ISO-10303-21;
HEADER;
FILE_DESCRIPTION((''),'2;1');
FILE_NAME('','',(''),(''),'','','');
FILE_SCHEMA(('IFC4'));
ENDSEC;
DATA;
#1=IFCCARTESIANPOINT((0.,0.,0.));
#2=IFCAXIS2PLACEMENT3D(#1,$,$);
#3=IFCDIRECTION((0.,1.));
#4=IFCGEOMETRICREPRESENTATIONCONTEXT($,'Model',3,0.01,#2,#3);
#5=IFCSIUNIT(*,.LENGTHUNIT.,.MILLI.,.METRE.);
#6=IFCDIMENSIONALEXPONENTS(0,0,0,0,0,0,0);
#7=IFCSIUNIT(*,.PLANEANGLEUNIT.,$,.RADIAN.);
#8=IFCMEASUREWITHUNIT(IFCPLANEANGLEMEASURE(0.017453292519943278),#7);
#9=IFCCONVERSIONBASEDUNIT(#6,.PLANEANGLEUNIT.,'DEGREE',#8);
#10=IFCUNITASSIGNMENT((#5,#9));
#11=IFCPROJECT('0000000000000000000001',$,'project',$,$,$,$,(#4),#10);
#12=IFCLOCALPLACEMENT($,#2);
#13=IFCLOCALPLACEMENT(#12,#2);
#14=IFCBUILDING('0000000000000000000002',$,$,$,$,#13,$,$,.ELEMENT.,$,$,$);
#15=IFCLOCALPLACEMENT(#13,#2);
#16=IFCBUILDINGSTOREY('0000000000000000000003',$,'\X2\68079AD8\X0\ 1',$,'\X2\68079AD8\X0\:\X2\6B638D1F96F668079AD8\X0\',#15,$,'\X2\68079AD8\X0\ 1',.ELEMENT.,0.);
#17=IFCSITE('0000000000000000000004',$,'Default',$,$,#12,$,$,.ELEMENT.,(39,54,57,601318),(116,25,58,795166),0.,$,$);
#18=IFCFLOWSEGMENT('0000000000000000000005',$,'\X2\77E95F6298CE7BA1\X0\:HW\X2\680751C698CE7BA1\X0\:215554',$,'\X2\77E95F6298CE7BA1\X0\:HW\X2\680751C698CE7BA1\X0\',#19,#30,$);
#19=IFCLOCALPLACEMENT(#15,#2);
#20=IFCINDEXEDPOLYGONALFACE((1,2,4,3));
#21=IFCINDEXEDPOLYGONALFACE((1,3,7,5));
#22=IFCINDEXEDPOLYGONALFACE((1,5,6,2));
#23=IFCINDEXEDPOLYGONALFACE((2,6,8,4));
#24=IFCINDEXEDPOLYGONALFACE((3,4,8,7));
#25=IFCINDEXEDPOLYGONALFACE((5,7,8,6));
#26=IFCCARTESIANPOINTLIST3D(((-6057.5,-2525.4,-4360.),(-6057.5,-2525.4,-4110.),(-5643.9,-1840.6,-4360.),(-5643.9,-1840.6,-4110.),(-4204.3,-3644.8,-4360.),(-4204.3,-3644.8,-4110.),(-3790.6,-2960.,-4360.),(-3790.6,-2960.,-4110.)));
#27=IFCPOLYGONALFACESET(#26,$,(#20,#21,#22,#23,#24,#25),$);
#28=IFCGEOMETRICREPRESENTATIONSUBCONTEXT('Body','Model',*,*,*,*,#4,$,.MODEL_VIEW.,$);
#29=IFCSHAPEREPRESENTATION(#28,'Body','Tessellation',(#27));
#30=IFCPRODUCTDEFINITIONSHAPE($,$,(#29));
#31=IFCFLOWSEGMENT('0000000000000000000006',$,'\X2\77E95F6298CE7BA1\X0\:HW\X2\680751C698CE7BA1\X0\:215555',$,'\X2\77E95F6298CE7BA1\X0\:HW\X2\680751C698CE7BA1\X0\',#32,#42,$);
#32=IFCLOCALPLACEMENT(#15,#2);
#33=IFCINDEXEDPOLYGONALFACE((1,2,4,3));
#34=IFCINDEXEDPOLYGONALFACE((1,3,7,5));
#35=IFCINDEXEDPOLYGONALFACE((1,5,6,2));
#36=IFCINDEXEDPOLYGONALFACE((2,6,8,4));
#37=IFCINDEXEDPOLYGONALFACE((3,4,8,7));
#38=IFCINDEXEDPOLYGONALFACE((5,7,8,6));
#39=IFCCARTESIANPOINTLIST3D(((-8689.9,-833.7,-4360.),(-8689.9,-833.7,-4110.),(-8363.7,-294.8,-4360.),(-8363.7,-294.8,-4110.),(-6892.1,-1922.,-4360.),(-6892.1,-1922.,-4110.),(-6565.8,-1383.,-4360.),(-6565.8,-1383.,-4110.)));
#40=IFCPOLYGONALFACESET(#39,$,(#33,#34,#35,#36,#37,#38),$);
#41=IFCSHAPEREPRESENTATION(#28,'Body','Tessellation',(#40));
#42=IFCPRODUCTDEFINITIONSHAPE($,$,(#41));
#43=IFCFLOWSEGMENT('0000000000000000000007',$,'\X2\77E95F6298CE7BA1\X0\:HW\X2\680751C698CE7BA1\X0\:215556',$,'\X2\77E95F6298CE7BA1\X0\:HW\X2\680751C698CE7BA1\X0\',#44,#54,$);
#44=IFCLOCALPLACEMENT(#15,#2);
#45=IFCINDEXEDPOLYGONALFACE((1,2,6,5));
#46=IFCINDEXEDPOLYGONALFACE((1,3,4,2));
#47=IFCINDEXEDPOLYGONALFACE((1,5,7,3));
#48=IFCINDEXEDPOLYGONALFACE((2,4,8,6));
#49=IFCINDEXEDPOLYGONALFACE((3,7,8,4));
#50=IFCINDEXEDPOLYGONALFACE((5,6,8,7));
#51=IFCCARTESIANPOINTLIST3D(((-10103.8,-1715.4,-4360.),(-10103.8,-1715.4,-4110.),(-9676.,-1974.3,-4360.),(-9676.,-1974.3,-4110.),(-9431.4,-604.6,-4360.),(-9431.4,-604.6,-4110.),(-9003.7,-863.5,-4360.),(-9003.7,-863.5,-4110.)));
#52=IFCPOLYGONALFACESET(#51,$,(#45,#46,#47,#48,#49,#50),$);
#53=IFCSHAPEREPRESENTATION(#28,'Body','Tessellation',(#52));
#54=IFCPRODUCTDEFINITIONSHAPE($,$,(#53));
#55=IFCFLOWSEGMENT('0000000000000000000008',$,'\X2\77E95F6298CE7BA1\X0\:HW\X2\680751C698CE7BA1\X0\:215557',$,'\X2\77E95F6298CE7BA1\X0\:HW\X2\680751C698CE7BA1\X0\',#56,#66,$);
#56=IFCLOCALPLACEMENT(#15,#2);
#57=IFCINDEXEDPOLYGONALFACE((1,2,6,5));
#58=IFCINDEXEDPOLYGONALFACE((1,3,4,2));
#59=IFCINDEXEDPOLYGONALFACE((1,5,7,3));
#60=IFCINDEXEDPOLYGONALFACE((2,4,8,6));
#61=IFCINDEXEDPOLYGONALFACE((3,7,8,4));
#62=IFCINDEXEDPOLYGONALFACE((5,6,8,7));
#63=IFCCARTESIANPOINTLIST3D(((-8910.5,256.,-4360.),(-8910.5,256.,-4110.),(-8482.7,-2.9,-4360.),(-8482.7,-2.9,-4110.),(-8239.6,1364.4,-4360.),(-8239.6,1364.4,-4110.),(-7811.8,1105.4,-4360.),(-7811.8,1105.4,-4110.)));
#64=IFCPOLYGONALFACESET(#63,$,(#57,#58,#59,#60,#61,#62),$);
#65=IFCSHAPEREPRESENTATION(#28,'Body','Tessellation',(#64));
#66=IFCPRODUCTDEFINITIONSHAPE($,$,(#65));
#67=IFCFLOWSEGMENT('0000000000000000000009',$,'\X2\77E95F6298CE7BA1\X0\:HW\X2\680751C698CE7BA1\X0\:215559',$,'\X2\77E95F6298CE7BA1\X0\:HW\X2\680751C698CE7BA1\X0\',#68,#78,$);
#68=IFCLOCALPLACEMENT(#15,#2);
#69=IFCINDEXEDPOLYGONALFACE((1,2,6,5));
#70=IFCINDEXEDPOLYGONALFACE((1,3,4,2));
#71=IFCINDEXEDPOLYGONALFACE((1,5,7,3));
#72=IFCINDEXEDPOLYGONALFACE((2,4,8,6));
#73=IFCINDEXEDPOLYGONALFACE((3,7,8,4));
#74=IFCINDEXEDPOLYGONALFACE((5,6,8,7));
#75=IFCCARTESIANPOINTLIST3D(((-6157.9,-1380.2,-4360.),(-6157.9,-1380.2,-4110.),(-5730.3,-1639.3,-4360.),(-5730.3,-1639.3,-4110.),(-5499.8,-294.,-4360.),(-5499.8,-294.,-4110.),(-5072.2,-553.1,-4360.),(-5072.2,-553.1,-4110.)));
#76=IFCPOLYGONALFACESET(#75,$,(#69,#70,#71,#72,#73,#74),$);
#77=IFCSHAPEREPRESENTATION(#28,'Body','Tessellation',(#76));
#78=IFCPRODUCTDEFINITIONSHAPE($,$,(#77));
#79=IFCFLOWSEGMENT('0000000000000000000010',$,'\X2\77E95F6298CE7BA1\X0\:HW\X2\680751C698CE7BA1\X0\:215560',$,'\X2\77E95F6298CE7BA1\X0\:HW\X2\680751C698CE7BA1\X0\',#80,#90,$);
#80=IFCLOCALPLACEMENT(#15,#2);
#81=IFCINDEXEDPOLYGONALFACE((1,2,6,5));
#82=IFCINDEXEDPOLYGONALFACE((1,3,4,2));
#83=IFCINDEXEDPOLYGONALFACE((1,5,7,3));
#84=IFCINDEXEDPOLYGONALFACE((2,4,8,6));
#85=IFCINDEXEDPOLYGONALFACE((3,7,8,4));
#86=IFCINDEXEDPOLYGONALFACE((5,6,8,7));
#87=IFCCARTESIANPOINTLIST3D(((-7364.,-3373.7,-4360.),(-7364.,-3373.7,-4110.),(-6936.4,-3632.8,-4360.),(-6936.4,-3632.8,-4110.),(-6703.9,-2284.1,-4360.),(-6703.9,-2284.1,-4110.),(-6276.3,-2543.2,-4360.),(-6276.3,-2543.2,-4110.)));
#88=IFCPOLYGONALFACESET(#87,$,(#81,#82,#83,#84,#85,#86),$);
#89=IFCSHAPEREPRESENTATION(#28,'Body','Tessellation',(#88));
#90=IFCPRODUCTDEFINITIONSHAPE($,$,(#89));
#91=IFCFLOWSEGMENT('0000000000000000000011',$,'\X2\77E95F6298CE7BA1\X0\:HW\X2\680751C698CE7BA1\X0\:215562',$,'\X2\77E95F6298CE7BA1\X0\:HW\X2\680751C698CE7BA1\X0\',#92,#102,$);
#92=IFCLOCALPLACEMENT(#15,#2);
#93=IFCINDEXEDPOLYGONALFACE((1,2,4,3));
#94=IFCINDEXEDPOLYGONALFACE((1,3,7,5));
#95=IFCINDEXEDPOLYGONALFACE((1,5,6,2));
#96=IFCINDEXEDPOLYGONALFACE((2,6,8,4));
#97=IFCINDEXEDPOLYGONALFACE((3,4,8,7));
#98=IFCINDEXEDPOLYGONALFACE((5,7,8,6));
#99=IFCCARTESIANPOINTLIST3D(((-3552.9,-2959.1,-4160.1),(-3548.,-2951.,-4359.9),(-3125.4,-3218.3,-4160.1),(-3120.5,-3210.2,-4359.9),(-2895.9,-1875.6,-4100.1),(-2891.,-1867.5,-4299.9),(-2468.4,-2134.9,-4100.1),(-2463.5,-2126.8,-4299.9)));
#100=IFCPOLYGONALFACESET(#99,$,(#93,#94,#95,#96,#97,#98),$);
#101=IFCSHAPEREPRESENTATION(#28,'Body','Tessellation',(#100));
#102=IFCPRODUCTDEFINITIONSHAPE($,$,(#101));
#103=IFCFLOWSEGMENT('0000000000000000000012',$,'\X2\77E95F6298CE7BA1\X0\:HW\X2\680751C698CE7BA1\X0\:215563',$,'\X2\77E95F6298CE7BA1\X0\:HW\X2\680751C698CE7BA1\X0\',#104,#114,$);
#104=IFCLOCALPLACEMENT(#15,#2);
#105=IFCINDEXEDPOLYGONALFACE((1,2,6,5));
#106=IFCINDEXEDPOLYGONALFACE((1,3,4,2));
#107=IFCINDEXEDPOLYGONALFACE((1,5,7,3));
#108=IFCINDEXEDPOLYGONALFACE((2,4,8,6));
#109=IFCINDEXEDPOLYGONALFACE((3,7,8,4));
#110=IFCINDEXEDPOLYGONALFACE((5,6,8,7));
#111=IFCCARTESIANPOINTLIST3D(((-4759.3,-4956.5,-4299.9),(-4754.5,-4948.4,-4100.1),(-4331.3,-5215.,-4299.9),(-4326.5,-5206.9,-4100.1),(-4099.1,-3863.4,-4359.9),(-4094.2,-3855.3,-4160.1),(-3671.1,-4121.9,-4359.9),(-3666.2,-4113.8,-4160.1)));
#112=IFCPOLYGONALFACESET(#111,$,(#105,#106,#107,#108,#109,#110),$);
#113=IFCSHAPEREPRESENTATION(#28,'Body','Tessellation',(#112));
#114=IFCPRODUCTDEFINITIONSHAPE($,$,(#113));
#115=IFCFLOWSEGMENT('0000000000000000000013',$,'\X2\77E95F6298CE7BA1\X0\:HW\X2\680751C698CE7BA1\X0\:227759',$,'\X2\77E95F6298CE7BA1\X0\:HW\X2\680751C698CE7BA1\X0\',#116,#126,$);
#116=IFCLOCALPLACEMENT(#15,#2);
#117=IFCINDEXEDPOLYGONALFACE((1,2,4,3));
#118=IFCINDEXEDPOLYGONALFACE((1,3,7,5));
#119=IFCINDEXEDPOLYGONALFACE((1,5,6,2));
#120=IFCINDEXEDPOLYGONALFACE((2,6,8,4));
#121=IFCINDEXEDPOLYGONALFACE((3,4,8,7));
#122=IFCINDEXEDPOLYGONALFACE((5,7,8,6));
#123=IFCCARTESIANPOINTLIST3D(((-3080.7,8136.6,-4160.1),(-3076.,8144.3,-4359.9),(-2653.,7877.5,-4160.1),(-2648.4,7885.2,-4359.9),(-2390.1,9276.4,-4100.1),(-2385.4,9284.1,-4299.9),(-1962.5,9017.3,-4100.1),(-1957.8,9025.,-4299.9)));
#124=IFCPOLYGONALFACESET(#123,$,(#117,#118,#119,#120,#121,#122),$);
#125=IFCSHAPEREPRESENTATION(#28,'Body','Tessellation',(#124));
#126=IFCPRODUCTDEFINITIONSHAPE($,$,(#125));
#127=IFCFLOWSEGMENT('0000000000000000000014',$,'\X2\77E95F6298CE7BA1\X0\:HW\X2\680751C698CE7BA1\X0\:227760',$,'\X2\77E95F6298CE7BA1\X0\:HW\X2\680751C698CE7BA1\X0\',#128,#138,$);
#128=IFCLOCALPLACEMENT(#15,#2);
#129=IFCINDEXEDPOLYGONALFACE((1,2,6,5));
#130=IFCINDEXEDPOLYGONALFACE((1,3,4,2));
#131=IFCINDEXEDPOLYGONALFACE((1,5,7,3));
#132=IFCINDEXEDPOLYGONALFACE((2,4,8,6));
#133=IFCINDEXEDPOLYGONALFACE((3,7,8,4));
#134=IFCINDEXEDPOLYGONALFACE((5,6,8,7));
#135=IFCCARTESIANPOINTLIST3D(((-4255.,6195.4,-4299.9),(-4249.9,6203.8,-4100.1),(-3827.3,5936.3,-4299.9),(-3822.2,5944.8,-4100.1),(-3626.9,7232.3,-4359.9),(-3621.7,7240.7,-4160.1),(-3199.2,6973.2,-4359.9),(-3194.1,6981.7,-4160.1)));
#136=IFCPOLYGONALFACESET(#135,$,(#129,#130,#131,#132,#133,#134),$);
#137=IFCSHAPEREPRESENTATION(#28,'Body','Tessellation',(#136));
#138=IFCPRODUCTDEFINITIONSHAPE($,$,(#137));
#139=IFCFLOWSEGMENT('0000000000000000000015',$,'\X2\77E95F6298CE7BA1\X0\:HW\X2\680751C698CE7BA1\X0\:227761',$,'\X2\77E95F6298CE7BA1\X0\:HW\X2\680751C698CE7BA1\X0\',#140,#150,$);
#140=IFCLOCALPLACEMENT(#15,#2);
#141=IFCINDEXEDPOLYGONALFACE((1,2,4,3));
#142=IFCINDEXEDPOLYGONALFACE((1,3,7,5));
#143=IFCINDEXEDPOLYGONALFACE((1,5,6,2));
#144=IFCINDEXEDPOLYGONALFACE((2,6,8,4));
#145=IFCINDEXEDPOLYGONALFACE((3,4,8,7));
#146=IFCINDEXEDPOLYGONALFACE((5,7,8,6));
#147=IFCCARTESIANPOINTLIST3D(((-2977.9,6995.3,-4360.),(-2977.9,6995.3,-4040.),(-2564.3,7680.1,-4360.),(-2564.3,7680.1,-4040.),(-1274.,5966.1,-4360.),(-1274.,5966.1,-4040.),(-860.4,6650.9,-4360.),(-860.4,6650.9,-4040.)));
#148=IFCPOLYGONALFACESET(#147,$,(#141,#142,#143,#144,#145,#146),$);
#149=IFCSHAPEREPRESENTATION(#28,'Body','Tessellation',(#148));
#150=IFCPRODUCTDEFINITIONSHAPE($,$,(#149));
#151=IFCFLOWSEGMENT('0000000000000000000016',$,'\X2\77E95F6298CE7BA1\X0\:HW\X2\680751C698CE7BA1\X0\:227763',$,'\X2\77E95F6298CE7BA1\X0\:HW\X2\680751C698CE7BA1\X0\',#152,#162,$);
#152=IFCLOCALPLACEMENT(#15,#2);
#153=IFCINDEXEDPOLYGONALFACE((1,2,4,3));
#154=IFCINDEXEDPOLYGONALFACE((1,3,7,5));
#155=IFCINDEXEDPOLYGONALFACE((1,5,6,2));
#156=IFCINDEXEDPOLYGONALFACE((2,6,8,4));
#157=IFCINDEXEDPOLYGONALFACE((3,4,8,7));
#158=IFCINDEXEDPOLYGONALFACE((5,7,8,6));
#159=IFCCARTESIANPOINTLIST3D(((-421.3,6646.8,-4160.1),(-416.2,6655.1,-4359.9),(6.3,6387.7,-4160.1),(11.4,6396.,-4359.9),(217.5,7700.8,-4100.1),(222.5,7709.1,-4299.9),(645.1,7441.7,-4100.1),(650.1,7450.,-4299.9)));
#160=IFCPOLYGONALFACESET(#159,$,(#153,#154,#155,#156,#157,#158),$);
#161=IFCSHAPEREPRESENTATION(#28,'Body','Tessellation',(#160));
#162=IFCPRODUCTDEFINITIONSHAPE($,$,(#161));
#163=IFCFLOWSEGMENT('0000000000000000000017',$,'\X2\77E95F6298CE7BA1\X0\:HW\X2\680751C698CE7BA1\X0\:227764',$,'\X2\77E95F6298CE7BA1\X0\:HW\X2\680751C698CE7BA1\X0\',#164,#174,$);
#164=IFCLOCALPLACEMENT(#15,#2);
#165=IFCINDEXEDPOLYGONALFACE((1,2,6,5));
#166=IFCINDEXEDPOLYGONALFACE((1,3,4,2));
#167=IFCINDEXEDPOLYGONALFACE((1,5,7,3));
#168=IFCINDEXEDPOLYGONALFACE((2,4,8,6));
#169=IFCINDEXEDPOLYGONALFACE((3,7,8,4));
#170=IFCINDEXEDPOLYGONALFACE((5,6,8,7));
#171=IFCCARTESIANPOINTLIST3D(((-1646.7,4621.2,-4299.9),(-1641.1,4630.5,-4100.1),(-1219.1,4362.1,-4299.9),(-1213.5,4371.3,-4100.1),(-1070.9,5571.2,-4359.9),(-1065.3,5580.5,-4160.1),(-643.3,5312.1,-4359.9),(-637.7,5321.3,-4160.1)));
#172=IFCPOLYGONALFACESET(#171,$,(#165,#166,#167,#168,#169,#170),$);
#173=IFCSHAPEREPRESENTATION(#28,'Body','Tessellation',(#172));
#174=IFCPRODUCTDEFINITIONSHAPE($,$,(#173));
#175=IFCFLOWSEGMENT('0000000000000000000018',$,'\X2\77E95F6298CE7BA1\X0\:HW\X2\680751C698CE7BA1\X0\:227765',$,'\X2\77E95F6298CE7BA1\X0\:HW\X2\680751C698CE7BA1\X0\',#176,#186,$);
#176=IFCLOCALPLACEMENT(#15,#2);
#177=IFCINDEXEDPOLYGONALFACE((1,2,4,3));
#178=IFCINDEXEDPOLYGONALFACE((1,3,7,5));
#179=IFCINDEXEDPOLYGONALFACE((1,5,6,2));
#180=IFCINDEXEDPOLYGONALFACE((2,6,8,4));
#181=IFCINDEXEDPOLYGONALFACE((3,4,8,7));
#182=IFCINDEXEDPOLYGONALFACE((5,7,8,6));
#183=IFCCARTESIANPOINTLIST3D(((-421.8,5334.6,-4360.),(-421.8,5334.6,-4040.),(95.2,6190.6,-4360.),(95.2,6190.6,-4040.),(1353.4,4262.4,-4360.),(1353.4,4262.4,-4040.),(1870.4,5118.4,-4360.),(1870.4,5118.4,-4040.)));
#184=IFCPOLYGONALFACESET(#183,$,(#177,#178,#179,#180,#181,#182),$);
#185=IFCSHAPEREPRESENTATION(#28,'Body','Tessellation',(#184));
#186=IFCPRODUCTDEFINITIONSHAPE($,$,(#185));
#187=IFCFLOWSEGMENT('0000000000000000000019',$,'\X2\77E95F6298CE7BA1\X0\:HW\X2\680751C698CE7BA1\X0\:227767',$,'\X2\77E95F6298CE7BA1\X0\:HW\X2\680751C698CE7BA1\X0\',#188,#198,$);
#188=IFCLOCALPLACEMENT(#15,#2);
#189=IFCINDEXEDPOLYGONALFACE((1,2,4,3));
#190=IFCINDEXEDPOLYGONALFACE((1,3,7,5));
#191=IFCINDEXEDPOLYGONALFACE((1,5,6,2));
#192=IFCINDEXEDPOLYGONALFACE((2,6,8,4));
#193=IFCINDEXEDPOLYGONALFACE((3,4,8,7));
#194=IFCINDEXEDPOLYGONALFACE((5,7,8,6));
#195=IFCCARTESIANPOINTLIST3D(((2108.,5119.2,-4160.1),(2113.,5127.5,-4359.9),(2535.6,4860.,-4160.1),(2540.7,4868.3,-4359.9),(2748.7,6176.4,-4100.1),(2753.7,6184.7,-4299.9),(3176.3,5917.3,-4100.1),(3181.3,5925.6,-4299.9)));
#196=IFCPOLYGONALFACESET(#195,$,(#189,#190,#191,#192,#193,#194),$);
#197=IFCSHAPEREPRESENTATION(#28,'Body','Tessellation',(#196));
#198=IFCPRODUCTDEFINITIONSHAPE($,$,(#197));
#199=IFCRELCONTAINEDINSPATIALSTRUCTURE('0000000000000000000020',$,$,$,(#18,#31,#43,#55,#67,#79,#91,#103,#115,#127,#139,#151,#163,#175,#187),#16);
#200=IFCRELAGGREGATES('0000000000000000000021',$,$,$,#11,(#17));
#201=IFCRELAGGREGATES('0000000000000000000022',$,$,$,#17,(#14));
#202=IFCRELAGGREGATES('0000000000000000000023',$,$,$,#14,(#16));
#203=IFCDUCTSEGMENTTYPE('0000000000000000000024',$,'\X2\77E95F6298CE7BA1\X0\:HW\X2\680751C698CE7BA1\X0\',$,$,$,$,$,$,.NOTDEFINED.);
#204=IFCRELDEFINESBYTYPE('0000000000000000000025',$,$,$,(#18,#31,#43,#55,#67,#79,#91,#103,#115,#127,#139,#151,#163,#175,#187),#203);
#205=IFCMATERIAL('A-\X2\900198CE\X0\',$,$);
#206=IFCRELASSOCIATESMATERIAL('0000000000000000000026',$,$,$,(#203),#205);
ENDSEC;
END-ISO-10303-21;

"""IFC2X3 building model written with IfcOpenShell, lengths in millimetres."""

from ifc_helpers import new_model, entity, si_unit, converted_unit, direction, frame, frame_2d, origin, origin_2d_with_axis, place, context, subcontext, project, spatial, rectangle, extrude, material, type_object, element, save


model = new_model("IFC2X3")

# Units and contexts
model_context = context("Model", 3, precision=0.01, world=origin(), true_north=direction((0.0, 1.0)))
body_context = subcontext(model_context, "Body", "Model", "MODEL_VIEW")
ifc_project = project(units=[si_unit("LENGTHUNIT", "METRE", prefix="MILLI"), converted_unit("PLANEANGLEUNIT", "DEGREE", entity("IfcPlaneAngleMeasure", 0.017453292519943278), si_unit("PLANEANGLEUNIT", "RADIAN"), dimensions=[0, 0, 0, 0, 0, 0, 0])], contexts=[model_context])

# Site, building, storey
site_placement = place(None, origin())
site = spatial("IfcSite", under=ifc_project, at=site_placement, Name="Default", CompositionType="ELEMENT", RefLatitude=(39, 54, 57, 601318), RefLongitude=(116, 25, 58, 795166), RefElevation=0.0)
building_placement = place(site_placement, origin())
building = spatial("IfcBuilding", under=site, at=building_placement, CompositionType="ELEMENT")
storey_placement = place(building_placement, origin())
storey = spatial("IfcBuildingStorey", under=building, at=storey_placement, Name="标高 1", ObjectType="标高:正负零标高", LongName="标高 1", CompositionType="ELEMENT", Elevation=0.0)

# Flow segments
ifc_material = material(Name="A-送风")
duct_segment_type = type_object("IfcDuctSegmentType", Name="矩形风管:HW标准风管", PredefinedType="NOTDEFINED", material=ifc_material)
flow_segment_1_placement = place(storey_placement, origin())
element("IfcFlowSegment", 1, at=flow_segment_1_placement, inside=storey, type_object=duct_segment_type, Name="矩形风管:HW标准风管:215554", ObjectType="矩形风管:HW标准风管", context=body_context, shape_type="SweptSolid", body=[
    extrude(rectangle(XDim=2165.1, YDim=800.0, at=frame_2d((0.0, 0.0), x_axis=(1.0, 0.0))), frame((-4924.1, -2742.7, -4360.0), z_axis=(0.0, 0.0, 1.0), x_axis=(-0.855967, 0.517031, 0.0)), (0.0, 0.0, 1.0), 250.0),
])
flow_segment_2_placement = place(storey_placement, origin())
element("IfcFlowSegment", 2, at=flow_segment_2_placement, inside=storey, type_object=duct_segment_type, Name="矩形风管:HW标准风管:215555", ObjectType="矩形风管:HW标准风管", context=body_context, shape_type="SweptSolid", body=[
    extrude(rectangle(XDim=2101.5, YDim=630.0, at=frame_2d((0.0, 0.0), x_axis=(1.0, 0.0))), frame((-7627.9, -1108.4, -4360.0), z_axis=(0.0, 0.0, 1.0), x_axis=(-0.855477, 0.517841, 0.0)), (0.0, 0.0, 1.0), 250.0),
])
flow_segment_3_placement = place(storey_placement, origin())
element("IfcFlowSegment", 3, at=flow_segment_3_placement, inside=storey, type_object=duct_segment_type, Name="矩形风管:HW标准风管:215556", ObjectType="矩形风管:HW标准风管", context=body_context, shape_type="SweptSolid", body=[
    extrude(rectangle(XDim=1298.4, YDim=500.0, at=frame_2d((0.0, 0.0), x_axis=(1.0, 0.0))), frame((-9553.7, -1289.5, -4360.0), z_axis=(0.0, 0.0, 1.0), x_axis=(0.517838, 0.855478, 0.0)), (0.0, 0.0, 1.0), 250.0),
])
flow_segment_4_placement = place(storey_placement, origin())
element("IfcFlowSegment", 4, at=flow_segment_4_placement, inside=storey, type_object=duct_segment_type, Name="矩形风管:HW标准风管:215557", ObjectType="矩形风管:HW标准风管", context=body_context, shape_type="SweptSolid", body=[
    extrude(rectangle(XDim=1295.6, YDim=500.0, at=origin_2d_with_axis()), frame((-8361.1, 680.7, -4360.0), z_axis=(0.0, 0.0, 1.0), x_axis=(0.517843, 0.855476, 0.0)), (0.0, 0.0, 1.0), 250.0),
])
flow_segment_5_placement = place(storey_placement, origin())
element("IfcFlowSegment", 5, at=flow_segment_5_placement, inside=storey, type_object=duct_segment_type, Name="矩形风管:HW标准风管:215559", ObjectType="矩形风管:HW标准风管", context=body_context, shape_type="SweptSolid", body=[
    extrude(rectangle(XDim=1270.0, YDim=500.0, at=frame_2d((0.0, 0.0), x_axis=(1.0, 0.0))), frame((-5615.0, -966.6, -4360.0), z_axis=(0.0, 0.0, 1.0), x_axis=(-0.518182, -0.85527, 0.0)), (0.0, 0.0, 1.0), 250.0),
])
flow_segment_6_placement = place(storey_placement, origin())
element("IfcFlowSegment", 6, at=flow_segment_6_placement, inside=storey, type_object=duct_segment_type, Name="矩形风管:HW标准风管:215560", ObjectType="矩形风管:HW标准风管", context=body_context, shape_type="SweptSolid", body=[
    extrude(rectangle(XDim=1274.0, YDim=500.0, at=frame_2d((0.0, 0.0), x_axis=(1.0, 0.0))), frame((-6820.1, -2958.4, -4360.0), z_axis=(0.0, 0.0, 1.0), x_axis=(0.518177, 0.855274, 0.0)), (0.0, 0.0, 1.0), 250.0),
])
flow_segment_7_placement = place(storey_placement, origin())
element("IfcFlowSegment", 7, at=flow_segment_7_placement, inside=storey, type_object=duct_segment_type, Name="矩形风管:HW标准风管:215562", ObjectType="矩形风管:HW标准风管", context=body_context, shape_type="SweptSolid", body=[
    extrude(rectangle(XDim=200.0, YDim=500.0, at=frame_2d((0.0, 0.0), x_axis=(1.0, 0.0))), frame((-3336.7, -3084.7, -4260.0), z_axis=(0.517949, 0.854103, 0.047298), x_axis=(-0.024525, -0.040443, 0.998881)), (0.0, 0.0, 1.0), 1268.6),
])
flow_segment_8_placement = place(storey_placement, origin())
element("IfcFlowSegment", 8, at=flow_segment_8_placement, inside=storey, type_object=duct_segment_type, Name="矩形风管:HW标准风管:215563", ObjectType="矩形风管:HW标准风管", context=body_context, shape_type="SweptSolid", body=[
    extrude(rectangle(XDim=200.0, YDim=500.0, at=frame_2d((0.0, 0.0), x_axis=(0.0, 1.0))), frame((-4542.9, -5081.7, -4200.0), z_axis=(0.51643, 0.855042, -0.046933), x_axis=(-0.855985, 0.517, 0.0)), (0.0, 0.0, 1.0), 1278.4),
])
flow_segment_9_placement = place(storey_placement, origin())
element("IfcFlowSegment", 9, at=flow_segment_9_placement, inside=storey, type_object=duct_segment_type, Name="矩形风管:HW标准风管:227759", ObjectType="矩形风管:HW标准风管", context=body_context, shape_type="SweptSolid", body=[
    extrude(rectangle(XDim=200.0, YDim=500.0, at=frame_2d((0.0, 0.0), x_axis=(1.0, 0.0))), frame((-2864.5, 8010.9, -4260.0), z_axis=(0.51765, 0.854409, 0.044976), x_axis=(-0.023305, -0.038467, 0.998988)), (0.0, 0.0, 1.0), 1334.0),
])
flow_segment_10_placement = place(storey_placement, origin())
element("IfcFlowSegment", 10, at=flow_segment_10_placement, inside=storey, type_object=duct_segment_type, Name="矩形风管:HW标准风管:227760", ObjectType="矩形风管:HW标准风管", context=body_context, shape_type="SweptSolid", body=[
    extrude(rectangle(XDim=200.0, YDim=500.0, at=frame_2d((0.0, 0.0), x_axis=(0.0, 1.0))), frame((-4038.6, 6070.1, -4200.0), z_axis=(0.517486, 0.854263, -0.049432), x_axis=(-0.855309, 0.518119, 0.0)), (0.0, 0.0, 1.0), 1213.8),
])
flow_segment_11_placement = place(storey_placement, origin())
element("IfcFlowSegment", 11, at=flow_segment_11_placement, inside=storey, type_object=duct_segment_type, Name="矩形风管:HW标准风管:227761", ObjectType="矩形风管:HW标准风管", context=body_context, shape_type="SweptSolid", body=[
    extrude(rectangle(XDim=1990.6, YDim=800.0, at=frame_2d((0.0, 0.0), x_axis=(1.0, 0.0))), frame((-1919.2, 6823.1, -4360.0), z_axis=(0.0, 0.0, 1.0), x_axis=(0.855987, -0.516998, 0.0)), (0.0, 0.0, 1.0), 320.0),
])
flow_segment_12_placement = place(storey_placement, origin())
element("IfcFlowSegment", 12, at=flow_segment_12_placement, inside=storey, type_object=duct_segment_type, Name="矩形风管:HW标准风管:227763", ObjectType="矩形风管:HW标准风管", context=body_context, shape_type="SweptSolid", body=[
    extrude(rectangle(XDim=200.0, YDim=500.0, at=frame_2d((0.0, 0.0), x_axis=(1.0, 0.0))), frame((-205.0, 6521.4, -4260.0), z_axis=(0.517657, 0.854205, 0.048626), x_axis=(-0.025201, -0.041586, 0.998817)), (0.0, 0.0, 1.0), 1233.9),
])
flow_segment_13_placement = place(storey_placement, origin())
element("IfcFlowSegment", 13, at=flow_segment_13_placement, inside=storey, type_object=duct_segment_type, Name="矩形风管:HW标准风管:227764", ObjectType="矩形风管:HW标准风管", context=body_context, shape_type="SweptSolid", body=[
    extrude(rectangle(XDim=200.0, YDim=500.0, at=frame_2d((0.0, 0.0), x_axis=(0.0, 1.0))), frame((-1430.1, 4496.3, -4200.0), z_axis=(0.517563, 0.853944, -0.053932), x_axis=(-0.855189, 0.518317, 0.0)), (0.0, 0.0, 1.0), 1112.5),
])
flow_segment_14_placement = place(storey_placement, origin())
element("IfcFlowSegment", 14, at=flow_segment_14_placement, inside=storey, type_object=duct_segment_type, Name="矩形风管:HW标准风管:227765", ObjectType="矩形风管:HW标准风管", context=body_context, shape_type="SweptSolid", body=[
    extrude(rectangle(XDim=2073.8, YDim=1000.0, at=frame_2d((0.0, 0.0), x_axis=(1.0, 0.0))), frame((724.3, 5226.5, -4360.0), z_axis=(0.0, 0.0, 1.0), x_axis=(0.855987, -0.516998, 0.0)), (0.0, 0.0, 1.0), 320.0),
])
flow_segment_15_placement = place(storey_placement, origin())
element("IfcFlowSegment", 15, at=flow_segment_15_placement, inside=storey, type_object=duct_segment_type, Name="矩形风管:HW标准风管:227767", ObjectType="矩形风管:HW标准风管", context=body_context, shape_type="SweptSolid", body=[
    extrude(rectangle(XDim=200.0, YDim=500.0, at=frame_2d((0.0, 0.0), x_axis=(1.0, 0.0))), frame((2324.3, 4993.8, -4260.0), z_axis=(0.517659, 0.854212, 0.048478), x_axis=(-0.025125, -0.041459, 0.998824)), (0.0, 0.0, 1.0), 1237.7),
])

save(model, "model.ifc")
